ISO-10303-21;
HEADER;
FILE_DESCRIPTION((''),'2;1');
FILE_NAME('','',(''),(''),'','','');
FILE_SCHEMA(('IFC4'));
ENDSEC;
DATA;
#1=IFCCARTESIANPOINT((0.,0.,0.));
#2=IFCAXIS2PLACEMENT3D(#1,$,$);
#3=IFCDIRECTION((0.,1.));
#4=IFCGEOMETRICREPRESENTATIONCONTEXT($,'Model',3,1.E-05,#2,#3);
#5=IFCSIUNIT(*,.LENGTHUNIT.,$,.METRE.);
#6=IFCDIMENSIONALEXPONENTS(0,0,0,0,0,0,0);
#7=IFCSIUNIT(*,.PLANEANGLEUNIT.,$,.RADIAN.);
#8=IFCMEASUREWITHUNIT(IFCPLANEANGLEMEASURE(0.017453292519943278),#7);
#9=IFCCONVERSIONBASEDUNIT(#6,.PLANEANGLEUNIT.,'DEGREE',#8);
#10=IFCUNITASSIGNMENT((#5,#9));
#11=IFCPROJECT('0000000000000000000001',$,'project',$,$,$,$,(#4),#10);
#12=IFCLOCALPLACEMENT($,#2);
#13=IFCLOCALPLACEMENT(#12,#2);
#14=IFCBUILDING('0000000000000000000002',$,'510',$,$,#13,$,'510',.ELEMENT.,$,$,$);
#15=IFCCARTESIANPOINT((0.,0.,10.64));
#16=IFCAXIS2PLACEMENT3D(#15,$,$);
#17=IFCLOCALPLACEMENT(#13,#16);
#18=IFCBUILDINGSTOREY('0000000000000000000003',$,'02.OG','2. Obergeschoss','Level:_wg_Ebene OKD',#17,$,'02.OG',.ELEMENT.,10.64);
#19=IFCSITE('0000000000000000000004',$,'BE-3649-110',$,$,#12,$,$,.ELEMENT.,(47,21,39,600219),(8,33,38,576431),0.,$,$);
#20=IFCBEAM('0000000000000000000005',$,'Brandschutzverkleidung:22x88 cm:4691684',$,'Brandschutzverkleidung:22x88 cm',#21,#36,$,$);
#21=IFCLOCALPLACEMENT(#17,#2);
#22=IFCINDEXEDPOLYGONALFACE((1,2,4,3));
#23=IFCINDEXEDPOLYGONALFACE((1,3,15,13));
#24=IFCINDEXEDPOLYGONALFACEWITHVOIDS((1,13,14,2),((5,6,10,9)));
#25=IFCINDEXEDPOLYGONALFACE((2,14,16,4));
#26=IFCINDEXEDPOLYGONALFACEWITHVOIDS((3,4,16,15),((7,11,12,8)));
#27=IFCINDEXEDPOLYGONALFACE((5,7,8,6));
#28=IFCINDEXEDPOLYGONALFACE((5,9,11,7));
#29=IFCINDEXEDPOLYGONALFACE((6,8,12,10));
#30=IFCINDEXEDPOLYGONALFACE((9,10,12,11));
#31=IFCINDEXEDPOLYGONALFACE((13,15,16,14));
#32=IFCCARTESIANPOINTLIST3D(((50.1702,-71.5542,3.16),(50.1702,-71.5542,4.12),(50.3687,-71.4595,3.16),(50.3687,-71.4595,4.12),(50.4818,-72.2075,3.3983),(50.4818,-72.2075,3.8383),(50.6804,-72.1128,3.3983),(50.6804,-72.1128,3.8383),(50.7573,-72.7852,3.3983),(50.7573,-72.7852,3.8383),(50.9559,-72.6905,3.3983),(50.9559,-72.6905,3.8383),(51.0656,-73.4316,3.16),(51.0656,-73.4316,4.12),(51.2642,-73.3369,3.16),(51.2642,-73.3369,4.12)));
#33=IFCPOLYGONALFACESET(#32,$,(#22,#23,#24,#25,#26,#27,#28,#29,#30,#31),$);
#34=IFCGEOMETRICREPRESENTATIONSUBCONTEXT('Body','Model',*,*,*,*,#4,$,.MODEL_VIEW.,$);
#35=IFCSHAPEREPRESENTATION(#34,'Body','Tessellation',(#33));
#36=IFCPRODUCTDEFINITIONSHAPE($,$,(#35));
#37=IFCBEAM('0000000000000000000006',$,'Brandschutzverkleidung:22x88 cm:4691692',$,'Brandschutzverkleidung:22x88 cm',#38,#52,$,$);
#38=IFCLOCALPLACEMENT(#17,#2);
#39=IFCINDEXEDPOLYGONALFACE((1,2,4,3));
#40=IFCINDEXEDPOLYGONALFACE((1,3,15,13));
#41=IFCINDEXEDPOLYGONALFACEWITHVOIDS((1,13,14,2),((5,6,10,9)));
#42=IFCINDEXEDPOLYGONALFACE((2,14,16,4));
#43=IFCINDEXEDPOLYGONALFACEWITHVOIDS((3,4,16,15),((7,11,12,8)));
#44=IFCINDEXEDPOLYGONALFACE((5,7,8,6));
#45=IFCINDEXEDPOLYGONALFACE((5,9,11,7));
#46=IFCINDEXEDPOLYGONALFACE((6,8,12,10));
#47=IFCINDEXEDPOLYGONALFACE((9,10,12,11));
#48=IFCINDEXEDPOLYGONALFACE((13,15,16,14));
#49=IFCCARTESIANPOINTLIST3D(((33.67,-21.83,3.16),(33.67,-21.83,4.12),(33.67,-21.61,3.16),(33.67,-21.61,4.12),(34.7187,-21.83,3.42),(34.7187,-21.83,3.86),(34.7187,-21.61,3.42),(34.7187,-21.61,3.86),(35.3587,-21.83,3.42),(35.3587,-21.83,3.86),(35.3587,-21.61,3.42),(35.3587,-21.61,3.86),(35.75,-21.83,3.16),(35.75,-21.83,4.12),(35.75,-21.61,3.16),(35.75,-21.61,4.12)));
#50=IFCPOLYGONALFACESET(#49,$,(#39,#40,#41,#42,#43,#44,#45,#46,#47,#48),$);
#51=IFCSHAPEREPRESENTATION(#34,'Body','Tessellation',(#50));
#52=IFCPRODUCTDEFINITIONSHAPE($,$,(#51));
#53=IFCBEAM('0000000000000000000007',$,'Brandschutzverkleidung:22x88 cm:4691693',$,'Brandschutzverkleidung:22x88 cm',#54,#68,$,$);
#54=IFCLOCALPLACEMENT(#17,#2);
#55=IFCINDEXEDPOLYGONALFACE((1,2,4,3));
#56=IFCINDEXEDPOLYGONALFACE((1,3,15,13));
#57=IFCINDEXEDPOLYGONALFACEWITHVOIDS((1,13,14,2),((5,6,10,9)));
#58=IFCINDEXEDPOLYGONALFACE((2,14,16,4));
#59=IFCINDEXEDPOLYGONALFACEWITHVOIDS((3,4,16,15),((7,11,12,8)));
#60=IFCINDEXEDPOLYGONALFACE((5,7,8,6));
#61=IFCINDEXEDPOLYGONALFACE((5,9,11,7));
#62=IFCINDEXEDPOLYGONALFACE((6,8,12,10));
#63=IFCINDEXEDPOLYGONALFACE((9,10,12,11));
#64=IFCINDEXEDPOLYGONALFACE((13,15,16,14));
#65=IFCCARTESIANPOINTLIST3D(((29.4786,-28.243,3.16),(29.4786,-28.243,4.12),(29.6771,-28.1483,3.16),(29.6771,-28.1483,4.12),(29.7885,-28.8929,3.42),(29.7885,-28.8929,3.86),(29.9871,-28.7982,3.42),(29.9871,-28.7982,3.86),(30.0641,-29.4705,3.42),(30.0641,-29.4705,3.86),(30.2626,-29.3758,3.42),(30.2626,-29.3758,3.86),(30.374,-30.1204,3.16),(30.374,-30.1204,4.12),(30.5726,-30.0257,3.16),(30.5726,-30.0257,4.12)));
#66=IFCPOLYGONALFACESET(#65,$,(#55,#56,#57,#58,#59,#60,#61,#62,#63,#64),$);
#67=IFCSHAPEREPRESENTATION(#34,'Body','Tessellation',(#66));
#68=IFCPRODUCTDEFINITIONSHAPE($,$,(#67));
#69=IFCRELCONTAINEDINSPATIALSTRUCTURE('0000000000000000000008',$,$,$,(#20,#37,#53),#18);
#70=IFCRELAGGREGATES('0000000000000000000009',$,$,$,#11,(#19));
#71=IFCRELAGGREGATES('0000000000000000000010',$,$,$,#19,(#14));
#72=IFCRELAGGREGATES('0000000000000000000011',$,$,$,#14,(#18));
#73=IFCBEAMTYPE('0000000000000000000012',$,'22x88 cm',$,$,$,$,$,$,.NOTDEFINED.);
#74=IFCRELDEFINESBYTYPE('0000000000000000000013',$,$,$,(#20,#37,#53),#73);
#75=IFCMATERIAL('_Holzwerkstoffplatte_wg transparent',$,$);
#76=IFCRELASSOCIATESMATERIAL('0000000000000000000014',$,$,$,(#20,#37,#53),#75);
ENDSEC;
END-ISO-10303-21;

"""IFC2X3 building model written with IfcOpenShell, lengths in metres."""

from ifc_helpers import new_model, entity, si_unit, converted_unit, direction, frame, origin, place, context, subcontext, project, spatial, polyline, outline, extrude, material, type_object, element, save


model = new_model("IFC2X3")

# Units and contexts
model_context = context("Model", 3, precision=1e-05, world=origin(), true_north=direction((0.0, 1.0)))
body_context = subcontext(model_context, "Body", "Model", "MODEL_VIEW")
ifc_project = project(units=[si_unit("LENGTHUNIT", "METRE"), converted_unit("PLANEANGLEUNIT", "DEGREE", entity("IfcPlaneAngleMeasure", 0.017453292519943278), si_unit("PLANEANGLEUNIT", "RADIAN"), dimensions=[0, 0, 0, 0, 0, 0, 0])], contexts=[model_context])

# Site, building, storey
site_placement = place(None, origin())
site = spatial("IfcSite", under=ifc_project, at=site_placement, Name="BE-3649-110", CompositionType="ELEMENT", RefLatitude=(47, 21, 39, 600219), RefLongitude=(8, 33, 38, 576431), RefElevation=0.0)
building_placement = place(site_placement, origin())
building = spatial("IfcBuilding", under=site, at=building_placement, Name="510", LongName="510", CompositionType="ELEMENT")
storey_placement = place(building_placement, frame((0.0, 0.0, 10.64)))
storey = spatial("IfcBuildingStorey", under=building, at=storey_placement, Name="02.OG", Description="2. Obergeschoss", ObjectType="Level:_wg_Ebene OKD", LongName="02.OG", CompositionType="ELEMENT", Elevation=10.64)

# Beams
ifc_material_1 = material(Name="_Holzwerkstoffplatte_wg transparent")
beam_type_1 = type_object("IfcBeamType", Name="22x88 cm", PredefinedType="NOTDEFINED")
beam_1_placement = place(storey_placement, frame((0.0, 0.0, 3.64)))
element("IfcBeam", 1, at=beam_1_placement, inside=storey, type_object=beam_type_1, material=ifc_material_1, Name="Brandschutzverkleidung:22x88 cm:4691684", ObjectType="Brandschutzverkleidung:22x88 cm", context=body_context, shape_type="SweptSolid", body=[
    extrude(outline(polyline([(-1.04, -0.48), (1.04, -0.48), (1.04, 0.48), (-1.04, 0.48), (-1.04, -0.48)]), holes=[polyline([(0.3238, 0.2417), (0.3238, -0.1983), (-0.3162, -0.1983), (-0.3162, 0.2417), (0.3238, 0.2417)])]), frame((50.6179, -72.4929, 0.0), z_axis=(0.902585, 0.430511, 0.0), x_axis=(0.430511, -0.902585, 0.0)), (0.0, 0.0, 1.0), 0.22),
])
beam_2_placement = place(storey_placement, frame((0.0, 0.0, 3.64)))
element("IfcBeam", 2, at=beam_2_placement, inside=storey, type_object=beam_type_1, material=ifc_material_1, Name="Brandschutzverkleidung:22x88 cm:4691692", ObjectType="Brandschutzverkleidung:22x88 cm", context=body_context, shape_type="SweptSolid", body=[
    extrude(outline(polyline([(-1.04, -0.48), (1.04, -0.48), (1.04, 0.48), (-1.04, 0.48), (-1.04, -0.48)]), holes=[polyline([(0.6487, 0.22), (0.6487, -0.22), (0.0087, -0.22), (0.0087, 0.22), (0.6487, 0.22)])]), frame((34.71, -21.83, 0.0), z_axis=(0.0, 1.0, 0.0), x_axis=(1.0, 0.0, 0.0)), (0.0, 0.0, 1.0), 0.22),
])
beam_3_placement = place(storey_placement, frame((0.0, 0.0, 3.64)))
element("IfcBeam", 3, at=beam_3_placement, inside=storey, type_object=beam_type_1, material=ifc_material_1, Name="Brandschutzverkleidung:22x88 cm:4691693", ObjectType="Brandschutzverkleidung:22x88 cm", context=body_context, shape_type="SweptSolid", body=[
    extrude(outline(polyline([(-1.04, -0.48), (1.04, -0.48), (1.04, 0.48), (-1.04, 0.48), (-1.04, -0.48)]), holes=[polyline([(-0.32, -0.22), (-0.32, 0.22), (0.32, 0.22), (0.32, -0.22), (-0.32, -0.22)])]), frame((29.9263, -29.1817, 0.0), z_axis=(0.902585, 0.430511, 0.0), x_axis=(-0.430511, 0.902585, 0.0)), (0.0, 0.0, 1.0), 0.22),
])

save(model, "model.ifc")
